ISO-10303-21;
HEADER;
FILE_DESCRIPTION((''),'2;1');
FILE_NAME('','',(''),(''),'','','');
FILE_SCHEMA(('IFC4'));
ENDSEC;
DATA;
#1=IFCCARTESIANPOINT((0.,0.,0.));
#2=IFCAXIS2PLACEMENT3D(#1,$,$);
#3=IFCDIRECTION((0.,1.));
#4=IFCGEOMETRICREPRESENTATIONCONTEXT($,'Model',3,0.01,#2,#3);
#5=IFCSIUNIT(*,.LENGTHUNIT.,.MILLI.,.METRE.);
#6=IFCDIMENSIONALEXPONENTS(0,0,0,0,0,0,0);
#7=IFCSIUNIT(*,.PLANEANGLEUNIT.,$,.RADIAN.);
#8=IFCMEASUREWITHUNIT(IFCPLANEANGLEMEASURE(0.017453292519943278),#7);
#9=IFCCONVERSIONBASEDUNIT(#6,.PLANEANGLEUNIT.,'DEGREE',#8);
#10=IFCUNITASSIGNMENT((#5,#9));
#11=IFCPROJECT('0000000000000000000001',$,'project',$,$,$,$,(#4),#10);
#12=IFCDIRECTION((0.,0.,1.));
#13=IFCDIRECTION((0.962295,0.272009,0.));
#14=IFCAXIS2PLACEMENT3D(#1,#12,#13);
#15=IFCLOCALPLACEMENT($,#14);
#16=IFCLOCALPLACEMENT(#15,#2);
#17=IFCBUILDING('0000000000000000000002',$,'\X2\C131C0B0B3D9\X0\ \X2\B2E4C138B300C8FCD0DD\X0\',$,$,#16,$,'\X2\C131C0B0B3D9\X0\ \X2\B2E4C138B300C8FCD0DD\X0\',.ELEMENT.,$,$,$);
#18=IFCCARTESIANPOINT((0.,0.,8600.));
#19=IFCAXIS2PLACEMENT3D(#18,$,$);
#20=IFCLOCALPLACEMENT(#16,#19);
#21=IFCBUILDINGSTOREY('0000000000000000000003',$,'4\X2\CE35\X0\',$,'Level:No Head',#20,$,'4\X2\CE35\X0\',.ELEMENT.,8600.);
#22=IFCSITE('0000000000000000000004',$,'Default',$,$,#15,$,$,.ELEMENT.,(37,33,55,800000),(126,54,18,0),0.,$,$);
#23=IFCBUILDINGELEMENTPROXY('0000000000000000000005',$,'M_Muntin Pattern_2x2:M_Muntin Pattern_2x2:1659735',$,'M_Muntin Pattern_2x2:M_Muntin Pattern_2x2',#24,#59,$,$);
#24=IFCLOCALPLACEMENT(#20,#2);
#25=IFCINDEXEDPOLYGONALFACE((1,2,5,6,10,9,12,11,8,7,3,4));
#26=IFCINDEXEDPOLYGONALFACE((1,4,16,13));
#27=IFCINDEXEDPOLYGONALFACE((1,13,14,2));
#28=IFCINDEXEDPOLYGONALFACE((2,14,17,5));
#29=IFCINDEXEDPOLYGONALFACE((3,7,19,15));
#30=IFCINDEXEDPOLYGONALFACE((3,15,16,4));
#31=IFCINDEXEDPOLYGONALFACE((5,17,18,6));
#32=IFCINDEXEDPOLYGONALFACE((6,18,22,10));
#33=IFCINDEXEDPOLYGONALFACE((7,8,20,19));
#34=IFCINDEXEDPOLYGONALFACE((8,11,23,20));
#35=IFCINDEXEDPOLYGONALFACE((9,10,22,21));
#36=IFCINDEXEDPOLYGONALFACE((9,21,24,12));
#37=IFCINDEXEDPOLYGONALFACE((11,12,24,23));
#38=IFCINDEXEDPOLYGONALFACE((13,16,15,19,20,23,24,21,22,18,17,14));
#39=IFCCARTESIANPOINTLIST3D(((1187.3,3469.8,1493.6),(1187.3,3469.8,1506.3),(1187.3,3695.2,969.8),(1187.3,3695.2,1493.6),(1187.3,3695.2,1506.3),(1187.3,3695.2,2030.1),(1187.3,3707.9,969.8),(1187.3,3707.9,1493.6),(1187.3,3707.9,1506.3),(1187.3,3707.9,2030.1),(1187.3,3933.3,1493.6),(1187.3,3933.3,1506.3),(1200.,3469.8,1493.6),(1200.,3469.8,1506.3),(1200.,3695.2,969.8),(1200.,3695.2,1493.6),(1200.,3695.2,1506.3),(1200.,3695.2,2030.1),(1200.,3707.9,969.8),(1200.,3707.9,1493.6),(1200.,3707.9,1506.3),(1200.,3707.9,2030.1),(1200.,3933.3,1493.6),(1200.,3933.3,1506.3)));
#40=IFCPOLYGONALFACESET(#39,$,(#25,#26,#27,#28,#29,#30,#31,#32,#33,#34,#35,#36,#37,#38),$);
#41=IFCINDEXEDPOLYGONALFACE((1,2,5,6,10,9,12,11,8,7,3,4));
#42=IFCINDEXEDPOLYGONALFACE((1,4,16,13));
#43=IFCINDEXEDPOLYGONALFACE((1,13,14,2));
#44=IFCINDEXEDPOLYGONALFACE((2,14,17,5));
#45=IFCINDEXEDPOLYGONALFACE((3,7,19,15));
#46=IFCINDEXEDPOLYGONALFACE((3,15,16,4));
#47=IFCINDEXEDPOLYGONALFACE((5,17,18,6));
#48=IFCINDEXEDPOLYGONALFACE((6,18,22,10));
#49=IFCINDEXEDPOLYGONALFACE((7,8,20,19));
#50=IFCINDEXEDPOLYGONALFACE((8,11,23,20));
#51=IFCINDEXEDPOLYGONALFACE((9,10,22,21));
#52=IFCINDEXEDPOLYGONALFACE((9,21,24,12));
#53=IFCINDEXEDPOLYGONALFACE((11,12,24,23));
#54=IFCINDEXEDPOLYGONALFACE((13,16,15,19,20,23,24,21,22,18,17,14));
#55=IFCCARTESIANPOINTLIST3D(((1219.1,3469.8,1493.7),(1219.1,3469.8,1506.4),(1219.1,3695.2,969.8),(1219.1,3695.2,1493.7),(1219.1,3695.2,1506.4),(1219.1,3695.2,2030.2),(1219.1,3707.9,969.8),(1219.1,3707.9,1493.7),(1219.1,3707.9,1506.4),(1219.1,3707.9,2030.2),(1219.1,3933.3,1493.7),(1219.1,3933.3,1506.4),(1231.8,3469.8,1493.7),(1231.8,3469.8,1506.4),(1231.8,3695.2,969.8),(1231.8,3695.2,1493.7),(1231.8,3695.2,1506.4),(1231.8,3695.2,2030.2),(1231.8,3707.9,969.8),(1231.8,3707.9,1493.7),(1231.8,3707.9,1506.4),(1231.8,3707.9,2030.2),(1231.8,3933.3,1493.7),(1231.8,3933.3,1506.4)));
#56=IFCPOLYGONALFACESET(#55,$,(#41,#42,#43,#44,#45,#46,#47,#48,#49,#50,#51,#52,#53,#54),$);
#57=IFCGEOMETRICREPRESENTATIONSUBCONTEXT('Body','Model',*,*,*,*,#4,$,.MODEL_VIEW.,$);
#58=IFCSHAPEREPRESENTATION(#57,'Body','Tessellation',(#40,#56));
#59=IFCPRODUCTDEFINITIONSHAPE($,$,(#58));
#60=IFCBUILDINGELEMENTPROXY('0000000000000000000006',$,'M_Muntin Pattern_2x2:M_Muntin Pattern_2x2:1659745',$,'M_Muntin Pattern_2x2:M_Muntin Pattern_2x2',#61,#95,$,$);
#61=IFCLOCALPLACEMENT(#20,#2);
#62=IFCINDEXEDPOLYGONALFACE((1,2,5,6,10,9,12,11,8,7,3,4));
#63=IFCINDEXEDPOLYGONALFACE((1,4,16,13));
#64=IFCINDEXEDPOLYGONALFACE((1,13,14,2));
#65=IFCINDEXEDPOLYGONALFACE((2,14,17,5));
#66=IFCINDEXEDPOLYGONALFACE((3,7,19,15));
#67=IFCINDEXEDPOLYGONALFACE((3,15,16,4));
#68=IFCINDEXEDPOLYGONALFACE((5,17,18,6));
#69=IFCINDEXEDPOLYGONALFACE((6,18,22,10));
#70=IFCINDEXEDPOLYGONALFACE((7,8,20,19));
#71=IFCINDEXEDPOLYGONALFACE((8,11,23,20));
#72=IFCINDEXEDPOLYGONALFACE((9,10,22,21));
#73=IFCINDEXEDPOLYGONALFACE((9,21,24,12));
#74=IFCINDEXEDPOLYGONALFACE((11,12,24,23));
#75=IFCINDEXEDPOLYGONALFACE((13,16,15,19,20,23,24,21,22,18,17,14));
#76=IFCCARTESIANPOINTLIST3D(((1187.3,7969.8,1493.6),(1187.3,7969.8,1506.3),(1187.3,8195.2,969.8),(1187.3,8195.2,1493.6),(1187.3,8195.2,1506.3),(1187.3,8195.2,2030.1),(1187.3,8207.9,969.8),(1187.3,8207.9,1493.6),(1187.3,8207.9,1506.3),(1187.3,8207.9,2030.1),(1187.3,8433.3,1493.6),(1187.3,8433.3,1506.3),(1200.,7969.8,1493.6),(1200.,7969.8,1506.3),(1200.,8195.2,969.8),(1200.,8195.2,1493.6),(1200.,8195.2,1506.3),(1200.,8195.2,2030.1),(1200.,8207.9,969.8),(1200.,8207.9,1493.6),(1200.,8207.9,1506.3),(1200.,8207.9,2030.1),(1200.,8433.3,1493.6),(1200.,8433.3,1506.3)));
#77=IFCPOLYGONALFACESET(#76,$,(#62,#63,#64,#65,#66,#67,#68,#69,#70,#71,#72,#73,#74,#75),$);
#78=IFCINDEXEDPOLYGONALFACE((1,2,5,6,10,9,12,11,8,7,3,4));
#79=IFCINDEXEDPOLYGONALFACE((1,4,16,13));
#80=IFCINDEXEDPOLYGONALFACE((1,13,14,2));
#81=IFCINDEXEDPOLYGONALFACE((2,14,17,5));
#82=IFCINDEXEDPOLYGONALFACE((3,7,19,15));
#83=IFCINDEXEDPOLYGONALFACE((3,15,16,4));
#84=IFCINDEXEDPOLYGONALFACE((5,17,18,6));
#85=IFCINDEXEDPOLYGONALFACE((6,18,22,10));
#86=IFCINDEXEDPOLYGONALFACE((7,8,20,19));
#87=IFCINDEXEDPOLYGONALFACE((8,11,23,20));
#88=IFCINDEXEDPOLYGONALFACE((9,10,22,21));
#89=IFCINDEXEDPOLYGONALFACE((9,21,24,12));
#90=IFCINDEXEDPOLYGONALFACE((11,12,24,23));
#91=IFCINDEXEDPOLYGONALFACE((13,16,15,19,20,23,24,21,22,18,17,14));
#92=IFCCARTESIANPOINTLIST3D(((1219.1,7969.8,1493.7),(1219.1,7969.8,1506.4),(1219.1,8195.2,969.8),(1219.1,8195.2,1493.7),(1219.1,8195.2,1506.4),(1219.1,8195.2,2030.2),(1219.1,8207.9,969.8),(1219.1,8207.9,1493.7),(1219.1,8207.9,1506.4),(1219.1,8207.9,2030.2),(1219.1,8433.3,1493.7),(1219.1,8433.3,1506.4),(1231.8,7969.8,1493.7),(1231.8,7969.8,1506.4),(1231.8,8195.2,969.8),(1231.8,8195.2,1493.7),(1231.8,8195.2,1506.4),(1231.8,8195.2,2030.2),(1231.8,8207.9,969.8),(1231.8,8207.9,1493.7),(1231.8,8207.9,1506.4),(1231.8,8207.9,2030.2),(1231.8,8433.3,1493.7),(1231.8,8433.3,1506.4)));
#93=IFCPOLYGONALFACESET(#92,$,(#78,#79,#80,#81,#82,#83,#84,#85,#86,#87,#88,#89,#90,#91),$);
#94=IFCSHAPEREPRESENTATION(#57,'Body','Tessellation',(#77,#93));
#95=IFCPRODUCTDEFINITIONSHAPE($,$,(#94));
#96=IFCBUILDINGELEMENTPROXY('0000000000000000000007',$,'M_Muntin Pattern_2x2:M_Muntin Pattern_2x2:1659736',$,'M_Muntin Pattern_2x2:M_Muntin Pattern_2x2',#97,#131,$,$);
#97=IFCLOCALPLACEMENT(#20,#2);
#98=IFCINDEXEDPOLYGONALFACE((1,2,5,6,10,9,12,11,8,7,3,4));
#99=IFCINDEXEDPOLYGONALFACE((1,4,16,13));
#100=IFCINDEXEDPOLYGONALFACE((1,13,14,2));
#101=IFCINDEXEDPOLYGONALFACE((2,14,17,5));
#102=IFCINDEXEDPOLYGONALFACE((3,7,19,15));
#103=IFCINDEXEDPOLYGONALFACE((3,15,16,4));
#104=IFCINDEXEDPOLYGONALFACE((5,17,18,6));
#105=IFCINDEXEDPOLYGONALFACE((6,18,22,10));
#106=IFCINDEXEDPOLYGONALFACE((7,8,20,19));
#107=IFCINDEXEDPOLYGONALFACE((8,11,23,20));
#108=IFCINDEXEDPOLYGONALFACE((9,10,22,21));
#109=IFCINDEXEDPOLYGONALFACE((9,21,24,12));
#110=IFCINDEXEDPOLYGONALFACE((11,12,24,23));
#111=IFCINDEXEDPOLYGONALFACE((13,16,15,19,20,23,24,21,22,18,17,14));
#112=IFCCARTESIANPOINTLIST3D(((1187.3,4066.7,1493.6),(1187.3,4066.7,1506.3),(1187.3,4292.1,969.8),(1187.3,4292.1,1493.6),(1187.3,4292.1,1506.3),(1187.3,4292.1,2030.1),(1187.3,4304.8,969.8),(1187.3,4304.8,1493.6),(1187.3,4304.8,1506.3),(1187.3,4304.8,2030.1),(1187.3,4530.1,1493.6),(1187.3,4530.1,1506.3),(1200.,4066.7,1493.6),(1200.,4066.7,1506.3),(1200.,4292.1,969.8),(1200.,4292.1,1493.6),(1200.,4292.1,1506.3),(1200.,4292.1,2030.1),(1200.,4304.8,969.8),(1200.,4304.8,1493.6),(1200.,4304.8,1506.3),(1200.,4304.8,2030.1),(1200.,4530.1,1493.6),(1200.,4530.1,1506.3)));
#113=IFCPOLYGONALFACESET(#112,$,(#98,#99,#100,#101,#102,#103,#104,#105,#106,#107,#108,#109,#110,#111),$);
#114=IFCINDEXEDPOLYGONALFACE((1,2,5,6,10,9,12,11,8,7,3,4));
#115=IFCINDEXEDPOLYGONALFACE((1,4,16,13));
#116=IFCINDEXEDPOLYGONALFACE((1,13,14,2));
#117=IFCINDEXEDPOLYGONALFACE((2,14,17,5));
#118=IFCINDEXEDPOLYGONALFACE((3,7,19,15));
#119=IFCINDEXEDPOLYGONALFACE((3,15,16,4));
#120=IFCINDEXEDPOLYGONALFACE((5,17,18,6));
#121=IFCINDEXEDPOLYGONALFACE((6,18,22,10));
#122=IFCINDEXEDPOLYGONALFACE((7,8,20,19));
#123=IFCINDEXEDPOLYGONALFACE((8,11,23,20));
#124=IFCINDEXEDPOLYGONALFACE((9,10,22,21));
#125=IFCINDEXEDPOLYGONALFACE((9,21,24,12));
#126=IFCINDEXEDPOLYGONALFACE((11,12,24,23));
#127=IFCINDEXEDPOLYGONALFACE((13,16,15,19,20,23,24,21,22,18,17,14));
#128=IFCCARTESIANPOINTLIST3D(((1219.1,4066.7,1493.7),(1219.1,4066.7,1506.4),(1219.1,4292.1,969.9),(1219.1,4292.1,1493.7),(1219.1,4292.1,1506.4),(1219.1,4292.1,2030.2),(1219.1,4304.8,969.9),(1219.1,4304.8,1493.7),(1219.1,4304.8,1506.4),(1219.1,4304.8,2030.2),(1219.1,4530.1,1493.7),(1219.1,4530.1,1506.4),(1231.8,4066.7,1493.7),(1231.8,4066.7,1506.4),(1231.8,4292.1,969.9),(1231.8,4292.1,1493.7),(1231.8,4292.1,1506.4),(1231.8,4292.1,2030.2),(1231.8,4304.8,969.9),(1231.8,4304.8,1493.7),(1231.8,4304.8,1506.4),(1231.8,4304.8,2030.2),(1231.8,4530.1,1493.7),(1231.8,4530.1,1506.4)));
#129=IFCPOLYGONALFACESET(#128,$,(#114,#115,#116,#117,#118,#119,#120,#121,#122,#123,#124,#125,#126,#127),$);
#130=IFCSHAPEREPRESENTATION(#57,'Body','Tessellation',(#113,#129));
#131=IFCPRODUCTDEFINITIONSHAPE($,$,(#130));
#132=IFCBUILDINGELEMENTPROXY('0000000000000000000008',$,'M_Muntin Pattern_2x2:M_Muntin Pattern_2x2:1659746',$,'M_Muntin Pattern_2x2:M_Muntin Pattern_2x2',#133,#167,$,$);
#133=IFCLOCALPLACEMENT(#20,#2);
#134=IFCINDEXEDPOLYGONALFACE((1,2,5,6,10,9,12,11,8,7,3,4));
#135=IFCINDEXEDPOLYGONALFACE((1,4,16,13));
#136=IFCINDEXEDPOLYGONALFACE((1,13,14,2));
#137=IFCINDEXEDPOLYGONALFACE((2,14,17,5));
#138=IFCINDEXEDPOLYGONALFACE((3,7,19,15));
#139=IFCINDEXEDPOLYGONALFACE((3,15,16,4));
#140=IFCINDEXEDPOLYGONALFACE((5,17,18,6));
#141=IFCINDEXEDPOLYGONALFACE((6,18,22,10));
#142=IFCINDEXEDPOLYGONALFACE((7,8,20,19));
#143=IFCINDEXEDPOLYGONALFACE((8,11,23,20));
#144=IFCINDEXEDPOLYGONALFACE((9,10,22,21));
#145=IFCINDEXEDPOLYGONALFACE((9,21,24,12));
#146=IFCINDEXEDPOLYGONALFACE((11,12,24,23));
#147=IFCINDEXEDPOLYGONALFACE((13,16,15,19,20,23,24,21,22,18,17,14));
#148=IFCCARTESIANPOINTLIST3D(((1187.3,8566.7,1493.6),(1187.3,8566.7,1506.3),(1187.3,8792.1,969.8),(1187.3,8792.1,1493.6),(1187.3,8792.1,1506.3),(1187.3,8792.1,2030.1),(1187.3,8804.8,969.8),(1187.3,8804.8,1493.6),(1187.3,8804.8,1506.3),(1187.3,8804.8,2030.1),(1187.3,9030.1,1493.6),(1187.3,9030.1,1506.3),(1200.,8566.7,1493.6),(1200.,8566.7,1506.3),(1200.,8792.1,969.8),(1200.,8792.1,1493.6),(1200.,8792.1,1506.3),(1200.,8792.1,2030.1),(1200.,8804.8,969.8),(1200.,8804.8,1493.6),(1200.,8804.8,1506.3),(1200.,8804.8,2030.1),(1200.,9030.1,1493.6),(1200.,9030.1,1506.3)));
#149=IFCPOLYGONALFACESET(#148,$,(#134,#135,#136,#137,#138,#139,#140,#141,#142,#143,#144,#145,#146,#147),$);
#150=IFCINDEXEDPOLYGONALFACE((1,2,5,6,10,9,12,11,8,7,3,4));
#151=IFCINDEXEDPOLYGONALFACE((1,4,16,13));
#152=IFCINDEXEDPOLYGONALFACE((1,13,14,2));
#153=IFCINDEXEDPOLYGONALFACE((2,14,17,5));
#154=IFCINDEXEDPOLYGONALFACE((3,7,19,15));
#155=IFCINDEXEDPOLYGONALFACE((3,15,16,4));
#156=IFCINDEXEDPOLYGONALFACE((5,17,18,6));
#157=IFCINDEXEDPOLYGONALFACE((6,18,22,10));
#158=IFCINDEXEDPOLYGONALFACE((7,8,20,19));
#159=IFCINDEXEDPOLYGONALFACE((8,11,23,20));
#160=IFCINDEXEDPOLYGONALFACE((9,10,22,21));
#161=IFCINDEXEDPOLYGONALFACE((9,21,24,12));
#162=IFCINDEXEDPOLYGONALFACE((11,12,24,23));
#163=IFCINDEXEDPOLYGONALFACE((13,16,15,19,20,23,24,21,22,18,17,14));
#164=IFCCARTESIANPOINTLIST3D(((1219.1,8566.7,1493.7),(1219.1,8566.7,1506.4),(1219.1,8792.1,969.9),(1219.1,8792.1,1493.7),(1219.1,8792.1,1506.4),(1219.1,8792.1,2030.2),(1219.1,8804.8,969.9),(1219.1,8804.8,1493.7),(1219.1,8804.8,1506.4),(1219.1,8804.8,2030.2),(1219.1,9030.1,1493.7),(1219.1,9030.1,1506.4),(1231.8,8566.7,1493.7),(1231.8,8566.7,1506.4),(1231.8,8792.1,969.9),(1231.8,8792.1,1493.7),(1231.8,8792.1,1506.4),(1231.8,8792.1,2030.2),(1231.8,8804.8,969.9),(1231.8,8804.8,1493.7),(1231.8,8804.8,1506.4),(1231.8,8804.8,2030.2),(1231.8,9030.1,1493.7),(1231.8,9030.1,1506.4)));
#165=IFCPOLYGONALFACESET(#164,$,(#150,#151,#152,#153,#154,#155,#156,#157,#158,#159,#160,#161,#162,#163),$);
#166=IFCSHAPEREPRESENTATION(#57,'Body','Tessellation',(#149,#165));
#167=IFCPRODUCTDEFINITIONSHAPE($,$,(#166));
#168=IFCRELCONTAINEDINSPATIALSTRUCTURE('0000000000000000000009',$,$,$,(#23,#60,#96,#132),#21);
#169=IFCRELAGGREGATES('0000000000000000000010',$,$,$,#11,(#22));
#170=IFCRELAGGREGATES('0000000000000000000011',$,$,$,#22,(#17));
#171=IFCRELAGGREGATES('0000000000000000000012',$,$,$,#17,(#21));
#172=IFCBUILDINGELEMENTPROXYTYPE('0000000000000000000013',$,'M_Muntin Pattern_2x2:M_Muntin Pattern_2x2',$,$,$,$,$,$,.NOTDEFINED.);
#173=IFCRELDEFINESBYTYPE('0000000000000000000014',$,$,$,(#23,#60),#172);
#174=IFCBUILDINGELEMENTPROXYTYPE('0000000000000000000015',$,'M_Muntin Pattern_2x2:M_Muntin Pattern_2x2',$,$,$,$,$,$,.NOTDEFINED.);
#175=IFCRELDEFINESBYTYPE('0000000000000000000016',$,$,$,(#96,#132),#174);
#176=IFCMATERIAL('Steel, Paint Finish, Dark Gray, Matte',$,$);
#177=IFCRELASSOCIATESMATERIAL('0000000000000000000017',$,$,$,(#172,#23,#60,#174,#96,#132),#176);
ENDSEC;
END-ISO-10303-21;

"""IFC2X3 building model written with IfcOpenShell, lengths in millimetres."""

from ifc_helpers import new_model, entity, si_unit, converted_unit, direction, frame, origin, place, context, subcontext, project, spatial, polyline, outline, extrude, source, transform, mapped, material, type_object, type_shapes, element, save


model = new_model("IFC2X3")

# Units and contexts
model_context = context("Model", 3, precision=0.01, world=origin(), true_north=direction((0.0, 1.0)))
body_context = subcontext(model_context, "Body", "Model", "MODEL_VIEW")
ifc_project = project(units=[si_unit("LENGTHUNIT", "METRE", prefix="MILLI"), converted_unit("PLANEANGLEUNIT", "DEGREE", entity("IfcPlaneAngleMeasure", 0.017453292519943278), si_unit("PLANEANGLEUNIT", "RADIAN"), dimensions=[0, 0, 0, 0, 0, 0, 0])], contexts=[model_context])

# Site, building, storey
site_placement = place(None, frame((0.0, 0.0, 0.0), z_axis=(0.0, 0.0, 1.0), x_axis=(0.962295, 0.272009, 0.0)))
site = spatial("IfcSite", under=ifc_project, at=site_placement, Name="Default", CompositionType="ELEMENT", RefLatitude=(37, 33, 55, 800000), RefLongitude=(126, 54, 18, 0), RefElevation=0.0)
building_placement = place(site_placement, origin())
building = spatial("IfcBuilding", under=site, at=building_placement, Name="성산동 다세대주택", LongName="성산동 다세대주택", CompositionType="ELEMENT")
storey_placement = place(building_placement, frame((0.0, 0.0, 8600.0)))
storey = spatial("IfcBuildingStorey", under=building, at=storey_placement, Name="4층", ObjectType="Level:No Head", LongName="4층", CompositionType="ELEMENT", Elevation=8600.0)

# Building element proxies
ifc_material_1 = material(Name="Steel, Paint Finish, Dark Gray, Matte")
building_element_proxy_type_1 = type_object("IfcBuildingElementProxyType", Name="M_Muntin Pattern_2x2:M_Muntin Pattern_2x2", PredefinedType="NOTDEFINED", material=ifc_material_1)
shared_shape_1 = source(origin(), body_context, "Body", "SweptSolid", [
    extrude(outline(polyline([(6.4, -6.4), (530.1, -6.4), (530.1, 6.3), (6.4, 6.3), (6.4, 231.7), (-6.3, 231.7), (-6.3, 6.3), (-530.2, 6.3), (-530.2, -6.4), (-6.3, -6.4), (-6.3, -231.7), (6.4, -231.7), (6.4, -6.4)])), frame((0.0, 9.5, 530.1), z_axis=(0.0, 1.0, 0.0), x_axis=(0.0, 0.0, 1.0)), (0.0, 0.0, 1.0), 12.7),
    extrude(outline(polyline([(6.4, -6.4), (530.2, -6.4), (530.2, 6.3), (6.4, 6.3), (6.4, 231.7), (-6.3, 231.7), (-6.3, 6.3), (-530.2, 6.3), (-530.2, -6.4), (-6.3, -6.4), (-6.3, -231.7), (6.4, -231.7), (6.4, -6.4)])), frame((0.0, -22.2, 530.2), z_axis=(0.0, 1.0, 0.0), x_axis=(0.0, 0.0, 1.0)), (0.0, 0.0, 1.0), 12.7),
])
type_shapes(building_element_proxy_type_1, [shared_shape_1])
for number, where, z_axis, x_axis, name in (
    (1, (1209.5, 3701.6, 969.8), (0.0, 0.0, 1.0), (0.0, 1.0, 0.0), "M_Muntin Pattern_2x2:M_Muntin Pattern_2x2:1659735"),
    (2, (1209.5, 8201.6, 969.8), (0.0, 0.0, 1.0), (0.0, 1.0, 0.0), "M_Muntin Pattern_2x2:M_Muntin Pattern_2x2:1659745"),
):
    element("IfcBuildingElementProxy", number, at=place(storey_placement, frame(where, z_axis=z_axis, x_axis=x_axis)), inside=storey, type_object=building_element_proxy_type_1, material=ifc_material_1, Name=name, ObjectType="M_Muntin Pattern_2x2:M_Muntin Pattern_2x2", context=body_context, shape_type="MappedRepresentation", body=[
        mapped(shared_shape_1, transform((0.0, 0.0, 0.0), scale=1.0)),
    ])
building_element_proxy_type_2 = type_object("IfcBuildingElementProxyType", Name="M_Muntin Pattern_2x2:M_Muntin Pattern_2x2", PredefinedType="NOTDEFINED", material=ifc_material_1)
shared_shape_2 = source(origin(), body_context, "Body", "SweptSolid", [
    extrude(outline(polyline([(6.4, -6.4), (530.1, -6.4), (530.1, 6.3), (6.4, 6.3), (6.4, 231.7), (-6.3, 231.7), (-6.3, 6.3), (-530.2, 6.3), (-530.2, -6.4), (-6.3, -6.4), (-6.3, -231.7), (6.4, -231.7), (6.4, -6.4)])), frame((0.0, -22.2, 530.1), z_axis=(0.0, 1.0, 0.0), x_axis=(0.0, 0.0, 1.0)), (0.0, 0.0, 1.0), 12.7),
    extrude(outline(polyline([(6.4, -6.4), (530.2, -6.4), (530.2, 6.3), (6.4, 6.3), (6.4, 231.7), (-6.3, 231.7), (-6.3, 6.3), (-530.2, 6.3), (-530.2, -6.4), (-6.3, -6.4), (-6.3, -231.7), (6.4, -231.7), (6.4, -6.4)])), frame((0.0, 9.5, 530.2), z_axis=(0.0, 1.0, 0.0), x_axis=(0.0, 0.0, 1.0)), (0.0, 0.0, 1.0), 12.7),
])
type_shapes(building_element_proxy_type_2, [shared_shape_2])
for number, where, z_axis, x_axis, name in (
    (3, (1209.5, 4298.4, 969.9), (0.0, 0.0, 1.0), (0.0, -1.0, 0.0), "M_Muntin Pattern_2x2:M_Muntin Pattern_2x2:1659736"),
    (4, (1209.5, 8798.4, 969.9), (0.0, 0.0, 1.0), (0.0, -1.0, 0.0), "M_Muntin Pattern_2x2:M_Muntin Pattern_2x2:1659746"),
):
    element("IfcBuildingElementProxy", number, at=place(storey_placement, frame(where, z_axis=z_axis, x_axis=x_axis)), inside=storey, type_object=building_element_proxy_type_2, material=ifc_material_1, Name=name, ObjectType="M_Muntin Pattern_2x2:M_Muntin Pattern_2x2", context=body_context, shape_type="MappedRepresentation", body=[
        mapped(shared_shape_2, transform((0.0, 0.0, 0.0), scale=1.0)),
    ])

save(model, "model.ifc")
